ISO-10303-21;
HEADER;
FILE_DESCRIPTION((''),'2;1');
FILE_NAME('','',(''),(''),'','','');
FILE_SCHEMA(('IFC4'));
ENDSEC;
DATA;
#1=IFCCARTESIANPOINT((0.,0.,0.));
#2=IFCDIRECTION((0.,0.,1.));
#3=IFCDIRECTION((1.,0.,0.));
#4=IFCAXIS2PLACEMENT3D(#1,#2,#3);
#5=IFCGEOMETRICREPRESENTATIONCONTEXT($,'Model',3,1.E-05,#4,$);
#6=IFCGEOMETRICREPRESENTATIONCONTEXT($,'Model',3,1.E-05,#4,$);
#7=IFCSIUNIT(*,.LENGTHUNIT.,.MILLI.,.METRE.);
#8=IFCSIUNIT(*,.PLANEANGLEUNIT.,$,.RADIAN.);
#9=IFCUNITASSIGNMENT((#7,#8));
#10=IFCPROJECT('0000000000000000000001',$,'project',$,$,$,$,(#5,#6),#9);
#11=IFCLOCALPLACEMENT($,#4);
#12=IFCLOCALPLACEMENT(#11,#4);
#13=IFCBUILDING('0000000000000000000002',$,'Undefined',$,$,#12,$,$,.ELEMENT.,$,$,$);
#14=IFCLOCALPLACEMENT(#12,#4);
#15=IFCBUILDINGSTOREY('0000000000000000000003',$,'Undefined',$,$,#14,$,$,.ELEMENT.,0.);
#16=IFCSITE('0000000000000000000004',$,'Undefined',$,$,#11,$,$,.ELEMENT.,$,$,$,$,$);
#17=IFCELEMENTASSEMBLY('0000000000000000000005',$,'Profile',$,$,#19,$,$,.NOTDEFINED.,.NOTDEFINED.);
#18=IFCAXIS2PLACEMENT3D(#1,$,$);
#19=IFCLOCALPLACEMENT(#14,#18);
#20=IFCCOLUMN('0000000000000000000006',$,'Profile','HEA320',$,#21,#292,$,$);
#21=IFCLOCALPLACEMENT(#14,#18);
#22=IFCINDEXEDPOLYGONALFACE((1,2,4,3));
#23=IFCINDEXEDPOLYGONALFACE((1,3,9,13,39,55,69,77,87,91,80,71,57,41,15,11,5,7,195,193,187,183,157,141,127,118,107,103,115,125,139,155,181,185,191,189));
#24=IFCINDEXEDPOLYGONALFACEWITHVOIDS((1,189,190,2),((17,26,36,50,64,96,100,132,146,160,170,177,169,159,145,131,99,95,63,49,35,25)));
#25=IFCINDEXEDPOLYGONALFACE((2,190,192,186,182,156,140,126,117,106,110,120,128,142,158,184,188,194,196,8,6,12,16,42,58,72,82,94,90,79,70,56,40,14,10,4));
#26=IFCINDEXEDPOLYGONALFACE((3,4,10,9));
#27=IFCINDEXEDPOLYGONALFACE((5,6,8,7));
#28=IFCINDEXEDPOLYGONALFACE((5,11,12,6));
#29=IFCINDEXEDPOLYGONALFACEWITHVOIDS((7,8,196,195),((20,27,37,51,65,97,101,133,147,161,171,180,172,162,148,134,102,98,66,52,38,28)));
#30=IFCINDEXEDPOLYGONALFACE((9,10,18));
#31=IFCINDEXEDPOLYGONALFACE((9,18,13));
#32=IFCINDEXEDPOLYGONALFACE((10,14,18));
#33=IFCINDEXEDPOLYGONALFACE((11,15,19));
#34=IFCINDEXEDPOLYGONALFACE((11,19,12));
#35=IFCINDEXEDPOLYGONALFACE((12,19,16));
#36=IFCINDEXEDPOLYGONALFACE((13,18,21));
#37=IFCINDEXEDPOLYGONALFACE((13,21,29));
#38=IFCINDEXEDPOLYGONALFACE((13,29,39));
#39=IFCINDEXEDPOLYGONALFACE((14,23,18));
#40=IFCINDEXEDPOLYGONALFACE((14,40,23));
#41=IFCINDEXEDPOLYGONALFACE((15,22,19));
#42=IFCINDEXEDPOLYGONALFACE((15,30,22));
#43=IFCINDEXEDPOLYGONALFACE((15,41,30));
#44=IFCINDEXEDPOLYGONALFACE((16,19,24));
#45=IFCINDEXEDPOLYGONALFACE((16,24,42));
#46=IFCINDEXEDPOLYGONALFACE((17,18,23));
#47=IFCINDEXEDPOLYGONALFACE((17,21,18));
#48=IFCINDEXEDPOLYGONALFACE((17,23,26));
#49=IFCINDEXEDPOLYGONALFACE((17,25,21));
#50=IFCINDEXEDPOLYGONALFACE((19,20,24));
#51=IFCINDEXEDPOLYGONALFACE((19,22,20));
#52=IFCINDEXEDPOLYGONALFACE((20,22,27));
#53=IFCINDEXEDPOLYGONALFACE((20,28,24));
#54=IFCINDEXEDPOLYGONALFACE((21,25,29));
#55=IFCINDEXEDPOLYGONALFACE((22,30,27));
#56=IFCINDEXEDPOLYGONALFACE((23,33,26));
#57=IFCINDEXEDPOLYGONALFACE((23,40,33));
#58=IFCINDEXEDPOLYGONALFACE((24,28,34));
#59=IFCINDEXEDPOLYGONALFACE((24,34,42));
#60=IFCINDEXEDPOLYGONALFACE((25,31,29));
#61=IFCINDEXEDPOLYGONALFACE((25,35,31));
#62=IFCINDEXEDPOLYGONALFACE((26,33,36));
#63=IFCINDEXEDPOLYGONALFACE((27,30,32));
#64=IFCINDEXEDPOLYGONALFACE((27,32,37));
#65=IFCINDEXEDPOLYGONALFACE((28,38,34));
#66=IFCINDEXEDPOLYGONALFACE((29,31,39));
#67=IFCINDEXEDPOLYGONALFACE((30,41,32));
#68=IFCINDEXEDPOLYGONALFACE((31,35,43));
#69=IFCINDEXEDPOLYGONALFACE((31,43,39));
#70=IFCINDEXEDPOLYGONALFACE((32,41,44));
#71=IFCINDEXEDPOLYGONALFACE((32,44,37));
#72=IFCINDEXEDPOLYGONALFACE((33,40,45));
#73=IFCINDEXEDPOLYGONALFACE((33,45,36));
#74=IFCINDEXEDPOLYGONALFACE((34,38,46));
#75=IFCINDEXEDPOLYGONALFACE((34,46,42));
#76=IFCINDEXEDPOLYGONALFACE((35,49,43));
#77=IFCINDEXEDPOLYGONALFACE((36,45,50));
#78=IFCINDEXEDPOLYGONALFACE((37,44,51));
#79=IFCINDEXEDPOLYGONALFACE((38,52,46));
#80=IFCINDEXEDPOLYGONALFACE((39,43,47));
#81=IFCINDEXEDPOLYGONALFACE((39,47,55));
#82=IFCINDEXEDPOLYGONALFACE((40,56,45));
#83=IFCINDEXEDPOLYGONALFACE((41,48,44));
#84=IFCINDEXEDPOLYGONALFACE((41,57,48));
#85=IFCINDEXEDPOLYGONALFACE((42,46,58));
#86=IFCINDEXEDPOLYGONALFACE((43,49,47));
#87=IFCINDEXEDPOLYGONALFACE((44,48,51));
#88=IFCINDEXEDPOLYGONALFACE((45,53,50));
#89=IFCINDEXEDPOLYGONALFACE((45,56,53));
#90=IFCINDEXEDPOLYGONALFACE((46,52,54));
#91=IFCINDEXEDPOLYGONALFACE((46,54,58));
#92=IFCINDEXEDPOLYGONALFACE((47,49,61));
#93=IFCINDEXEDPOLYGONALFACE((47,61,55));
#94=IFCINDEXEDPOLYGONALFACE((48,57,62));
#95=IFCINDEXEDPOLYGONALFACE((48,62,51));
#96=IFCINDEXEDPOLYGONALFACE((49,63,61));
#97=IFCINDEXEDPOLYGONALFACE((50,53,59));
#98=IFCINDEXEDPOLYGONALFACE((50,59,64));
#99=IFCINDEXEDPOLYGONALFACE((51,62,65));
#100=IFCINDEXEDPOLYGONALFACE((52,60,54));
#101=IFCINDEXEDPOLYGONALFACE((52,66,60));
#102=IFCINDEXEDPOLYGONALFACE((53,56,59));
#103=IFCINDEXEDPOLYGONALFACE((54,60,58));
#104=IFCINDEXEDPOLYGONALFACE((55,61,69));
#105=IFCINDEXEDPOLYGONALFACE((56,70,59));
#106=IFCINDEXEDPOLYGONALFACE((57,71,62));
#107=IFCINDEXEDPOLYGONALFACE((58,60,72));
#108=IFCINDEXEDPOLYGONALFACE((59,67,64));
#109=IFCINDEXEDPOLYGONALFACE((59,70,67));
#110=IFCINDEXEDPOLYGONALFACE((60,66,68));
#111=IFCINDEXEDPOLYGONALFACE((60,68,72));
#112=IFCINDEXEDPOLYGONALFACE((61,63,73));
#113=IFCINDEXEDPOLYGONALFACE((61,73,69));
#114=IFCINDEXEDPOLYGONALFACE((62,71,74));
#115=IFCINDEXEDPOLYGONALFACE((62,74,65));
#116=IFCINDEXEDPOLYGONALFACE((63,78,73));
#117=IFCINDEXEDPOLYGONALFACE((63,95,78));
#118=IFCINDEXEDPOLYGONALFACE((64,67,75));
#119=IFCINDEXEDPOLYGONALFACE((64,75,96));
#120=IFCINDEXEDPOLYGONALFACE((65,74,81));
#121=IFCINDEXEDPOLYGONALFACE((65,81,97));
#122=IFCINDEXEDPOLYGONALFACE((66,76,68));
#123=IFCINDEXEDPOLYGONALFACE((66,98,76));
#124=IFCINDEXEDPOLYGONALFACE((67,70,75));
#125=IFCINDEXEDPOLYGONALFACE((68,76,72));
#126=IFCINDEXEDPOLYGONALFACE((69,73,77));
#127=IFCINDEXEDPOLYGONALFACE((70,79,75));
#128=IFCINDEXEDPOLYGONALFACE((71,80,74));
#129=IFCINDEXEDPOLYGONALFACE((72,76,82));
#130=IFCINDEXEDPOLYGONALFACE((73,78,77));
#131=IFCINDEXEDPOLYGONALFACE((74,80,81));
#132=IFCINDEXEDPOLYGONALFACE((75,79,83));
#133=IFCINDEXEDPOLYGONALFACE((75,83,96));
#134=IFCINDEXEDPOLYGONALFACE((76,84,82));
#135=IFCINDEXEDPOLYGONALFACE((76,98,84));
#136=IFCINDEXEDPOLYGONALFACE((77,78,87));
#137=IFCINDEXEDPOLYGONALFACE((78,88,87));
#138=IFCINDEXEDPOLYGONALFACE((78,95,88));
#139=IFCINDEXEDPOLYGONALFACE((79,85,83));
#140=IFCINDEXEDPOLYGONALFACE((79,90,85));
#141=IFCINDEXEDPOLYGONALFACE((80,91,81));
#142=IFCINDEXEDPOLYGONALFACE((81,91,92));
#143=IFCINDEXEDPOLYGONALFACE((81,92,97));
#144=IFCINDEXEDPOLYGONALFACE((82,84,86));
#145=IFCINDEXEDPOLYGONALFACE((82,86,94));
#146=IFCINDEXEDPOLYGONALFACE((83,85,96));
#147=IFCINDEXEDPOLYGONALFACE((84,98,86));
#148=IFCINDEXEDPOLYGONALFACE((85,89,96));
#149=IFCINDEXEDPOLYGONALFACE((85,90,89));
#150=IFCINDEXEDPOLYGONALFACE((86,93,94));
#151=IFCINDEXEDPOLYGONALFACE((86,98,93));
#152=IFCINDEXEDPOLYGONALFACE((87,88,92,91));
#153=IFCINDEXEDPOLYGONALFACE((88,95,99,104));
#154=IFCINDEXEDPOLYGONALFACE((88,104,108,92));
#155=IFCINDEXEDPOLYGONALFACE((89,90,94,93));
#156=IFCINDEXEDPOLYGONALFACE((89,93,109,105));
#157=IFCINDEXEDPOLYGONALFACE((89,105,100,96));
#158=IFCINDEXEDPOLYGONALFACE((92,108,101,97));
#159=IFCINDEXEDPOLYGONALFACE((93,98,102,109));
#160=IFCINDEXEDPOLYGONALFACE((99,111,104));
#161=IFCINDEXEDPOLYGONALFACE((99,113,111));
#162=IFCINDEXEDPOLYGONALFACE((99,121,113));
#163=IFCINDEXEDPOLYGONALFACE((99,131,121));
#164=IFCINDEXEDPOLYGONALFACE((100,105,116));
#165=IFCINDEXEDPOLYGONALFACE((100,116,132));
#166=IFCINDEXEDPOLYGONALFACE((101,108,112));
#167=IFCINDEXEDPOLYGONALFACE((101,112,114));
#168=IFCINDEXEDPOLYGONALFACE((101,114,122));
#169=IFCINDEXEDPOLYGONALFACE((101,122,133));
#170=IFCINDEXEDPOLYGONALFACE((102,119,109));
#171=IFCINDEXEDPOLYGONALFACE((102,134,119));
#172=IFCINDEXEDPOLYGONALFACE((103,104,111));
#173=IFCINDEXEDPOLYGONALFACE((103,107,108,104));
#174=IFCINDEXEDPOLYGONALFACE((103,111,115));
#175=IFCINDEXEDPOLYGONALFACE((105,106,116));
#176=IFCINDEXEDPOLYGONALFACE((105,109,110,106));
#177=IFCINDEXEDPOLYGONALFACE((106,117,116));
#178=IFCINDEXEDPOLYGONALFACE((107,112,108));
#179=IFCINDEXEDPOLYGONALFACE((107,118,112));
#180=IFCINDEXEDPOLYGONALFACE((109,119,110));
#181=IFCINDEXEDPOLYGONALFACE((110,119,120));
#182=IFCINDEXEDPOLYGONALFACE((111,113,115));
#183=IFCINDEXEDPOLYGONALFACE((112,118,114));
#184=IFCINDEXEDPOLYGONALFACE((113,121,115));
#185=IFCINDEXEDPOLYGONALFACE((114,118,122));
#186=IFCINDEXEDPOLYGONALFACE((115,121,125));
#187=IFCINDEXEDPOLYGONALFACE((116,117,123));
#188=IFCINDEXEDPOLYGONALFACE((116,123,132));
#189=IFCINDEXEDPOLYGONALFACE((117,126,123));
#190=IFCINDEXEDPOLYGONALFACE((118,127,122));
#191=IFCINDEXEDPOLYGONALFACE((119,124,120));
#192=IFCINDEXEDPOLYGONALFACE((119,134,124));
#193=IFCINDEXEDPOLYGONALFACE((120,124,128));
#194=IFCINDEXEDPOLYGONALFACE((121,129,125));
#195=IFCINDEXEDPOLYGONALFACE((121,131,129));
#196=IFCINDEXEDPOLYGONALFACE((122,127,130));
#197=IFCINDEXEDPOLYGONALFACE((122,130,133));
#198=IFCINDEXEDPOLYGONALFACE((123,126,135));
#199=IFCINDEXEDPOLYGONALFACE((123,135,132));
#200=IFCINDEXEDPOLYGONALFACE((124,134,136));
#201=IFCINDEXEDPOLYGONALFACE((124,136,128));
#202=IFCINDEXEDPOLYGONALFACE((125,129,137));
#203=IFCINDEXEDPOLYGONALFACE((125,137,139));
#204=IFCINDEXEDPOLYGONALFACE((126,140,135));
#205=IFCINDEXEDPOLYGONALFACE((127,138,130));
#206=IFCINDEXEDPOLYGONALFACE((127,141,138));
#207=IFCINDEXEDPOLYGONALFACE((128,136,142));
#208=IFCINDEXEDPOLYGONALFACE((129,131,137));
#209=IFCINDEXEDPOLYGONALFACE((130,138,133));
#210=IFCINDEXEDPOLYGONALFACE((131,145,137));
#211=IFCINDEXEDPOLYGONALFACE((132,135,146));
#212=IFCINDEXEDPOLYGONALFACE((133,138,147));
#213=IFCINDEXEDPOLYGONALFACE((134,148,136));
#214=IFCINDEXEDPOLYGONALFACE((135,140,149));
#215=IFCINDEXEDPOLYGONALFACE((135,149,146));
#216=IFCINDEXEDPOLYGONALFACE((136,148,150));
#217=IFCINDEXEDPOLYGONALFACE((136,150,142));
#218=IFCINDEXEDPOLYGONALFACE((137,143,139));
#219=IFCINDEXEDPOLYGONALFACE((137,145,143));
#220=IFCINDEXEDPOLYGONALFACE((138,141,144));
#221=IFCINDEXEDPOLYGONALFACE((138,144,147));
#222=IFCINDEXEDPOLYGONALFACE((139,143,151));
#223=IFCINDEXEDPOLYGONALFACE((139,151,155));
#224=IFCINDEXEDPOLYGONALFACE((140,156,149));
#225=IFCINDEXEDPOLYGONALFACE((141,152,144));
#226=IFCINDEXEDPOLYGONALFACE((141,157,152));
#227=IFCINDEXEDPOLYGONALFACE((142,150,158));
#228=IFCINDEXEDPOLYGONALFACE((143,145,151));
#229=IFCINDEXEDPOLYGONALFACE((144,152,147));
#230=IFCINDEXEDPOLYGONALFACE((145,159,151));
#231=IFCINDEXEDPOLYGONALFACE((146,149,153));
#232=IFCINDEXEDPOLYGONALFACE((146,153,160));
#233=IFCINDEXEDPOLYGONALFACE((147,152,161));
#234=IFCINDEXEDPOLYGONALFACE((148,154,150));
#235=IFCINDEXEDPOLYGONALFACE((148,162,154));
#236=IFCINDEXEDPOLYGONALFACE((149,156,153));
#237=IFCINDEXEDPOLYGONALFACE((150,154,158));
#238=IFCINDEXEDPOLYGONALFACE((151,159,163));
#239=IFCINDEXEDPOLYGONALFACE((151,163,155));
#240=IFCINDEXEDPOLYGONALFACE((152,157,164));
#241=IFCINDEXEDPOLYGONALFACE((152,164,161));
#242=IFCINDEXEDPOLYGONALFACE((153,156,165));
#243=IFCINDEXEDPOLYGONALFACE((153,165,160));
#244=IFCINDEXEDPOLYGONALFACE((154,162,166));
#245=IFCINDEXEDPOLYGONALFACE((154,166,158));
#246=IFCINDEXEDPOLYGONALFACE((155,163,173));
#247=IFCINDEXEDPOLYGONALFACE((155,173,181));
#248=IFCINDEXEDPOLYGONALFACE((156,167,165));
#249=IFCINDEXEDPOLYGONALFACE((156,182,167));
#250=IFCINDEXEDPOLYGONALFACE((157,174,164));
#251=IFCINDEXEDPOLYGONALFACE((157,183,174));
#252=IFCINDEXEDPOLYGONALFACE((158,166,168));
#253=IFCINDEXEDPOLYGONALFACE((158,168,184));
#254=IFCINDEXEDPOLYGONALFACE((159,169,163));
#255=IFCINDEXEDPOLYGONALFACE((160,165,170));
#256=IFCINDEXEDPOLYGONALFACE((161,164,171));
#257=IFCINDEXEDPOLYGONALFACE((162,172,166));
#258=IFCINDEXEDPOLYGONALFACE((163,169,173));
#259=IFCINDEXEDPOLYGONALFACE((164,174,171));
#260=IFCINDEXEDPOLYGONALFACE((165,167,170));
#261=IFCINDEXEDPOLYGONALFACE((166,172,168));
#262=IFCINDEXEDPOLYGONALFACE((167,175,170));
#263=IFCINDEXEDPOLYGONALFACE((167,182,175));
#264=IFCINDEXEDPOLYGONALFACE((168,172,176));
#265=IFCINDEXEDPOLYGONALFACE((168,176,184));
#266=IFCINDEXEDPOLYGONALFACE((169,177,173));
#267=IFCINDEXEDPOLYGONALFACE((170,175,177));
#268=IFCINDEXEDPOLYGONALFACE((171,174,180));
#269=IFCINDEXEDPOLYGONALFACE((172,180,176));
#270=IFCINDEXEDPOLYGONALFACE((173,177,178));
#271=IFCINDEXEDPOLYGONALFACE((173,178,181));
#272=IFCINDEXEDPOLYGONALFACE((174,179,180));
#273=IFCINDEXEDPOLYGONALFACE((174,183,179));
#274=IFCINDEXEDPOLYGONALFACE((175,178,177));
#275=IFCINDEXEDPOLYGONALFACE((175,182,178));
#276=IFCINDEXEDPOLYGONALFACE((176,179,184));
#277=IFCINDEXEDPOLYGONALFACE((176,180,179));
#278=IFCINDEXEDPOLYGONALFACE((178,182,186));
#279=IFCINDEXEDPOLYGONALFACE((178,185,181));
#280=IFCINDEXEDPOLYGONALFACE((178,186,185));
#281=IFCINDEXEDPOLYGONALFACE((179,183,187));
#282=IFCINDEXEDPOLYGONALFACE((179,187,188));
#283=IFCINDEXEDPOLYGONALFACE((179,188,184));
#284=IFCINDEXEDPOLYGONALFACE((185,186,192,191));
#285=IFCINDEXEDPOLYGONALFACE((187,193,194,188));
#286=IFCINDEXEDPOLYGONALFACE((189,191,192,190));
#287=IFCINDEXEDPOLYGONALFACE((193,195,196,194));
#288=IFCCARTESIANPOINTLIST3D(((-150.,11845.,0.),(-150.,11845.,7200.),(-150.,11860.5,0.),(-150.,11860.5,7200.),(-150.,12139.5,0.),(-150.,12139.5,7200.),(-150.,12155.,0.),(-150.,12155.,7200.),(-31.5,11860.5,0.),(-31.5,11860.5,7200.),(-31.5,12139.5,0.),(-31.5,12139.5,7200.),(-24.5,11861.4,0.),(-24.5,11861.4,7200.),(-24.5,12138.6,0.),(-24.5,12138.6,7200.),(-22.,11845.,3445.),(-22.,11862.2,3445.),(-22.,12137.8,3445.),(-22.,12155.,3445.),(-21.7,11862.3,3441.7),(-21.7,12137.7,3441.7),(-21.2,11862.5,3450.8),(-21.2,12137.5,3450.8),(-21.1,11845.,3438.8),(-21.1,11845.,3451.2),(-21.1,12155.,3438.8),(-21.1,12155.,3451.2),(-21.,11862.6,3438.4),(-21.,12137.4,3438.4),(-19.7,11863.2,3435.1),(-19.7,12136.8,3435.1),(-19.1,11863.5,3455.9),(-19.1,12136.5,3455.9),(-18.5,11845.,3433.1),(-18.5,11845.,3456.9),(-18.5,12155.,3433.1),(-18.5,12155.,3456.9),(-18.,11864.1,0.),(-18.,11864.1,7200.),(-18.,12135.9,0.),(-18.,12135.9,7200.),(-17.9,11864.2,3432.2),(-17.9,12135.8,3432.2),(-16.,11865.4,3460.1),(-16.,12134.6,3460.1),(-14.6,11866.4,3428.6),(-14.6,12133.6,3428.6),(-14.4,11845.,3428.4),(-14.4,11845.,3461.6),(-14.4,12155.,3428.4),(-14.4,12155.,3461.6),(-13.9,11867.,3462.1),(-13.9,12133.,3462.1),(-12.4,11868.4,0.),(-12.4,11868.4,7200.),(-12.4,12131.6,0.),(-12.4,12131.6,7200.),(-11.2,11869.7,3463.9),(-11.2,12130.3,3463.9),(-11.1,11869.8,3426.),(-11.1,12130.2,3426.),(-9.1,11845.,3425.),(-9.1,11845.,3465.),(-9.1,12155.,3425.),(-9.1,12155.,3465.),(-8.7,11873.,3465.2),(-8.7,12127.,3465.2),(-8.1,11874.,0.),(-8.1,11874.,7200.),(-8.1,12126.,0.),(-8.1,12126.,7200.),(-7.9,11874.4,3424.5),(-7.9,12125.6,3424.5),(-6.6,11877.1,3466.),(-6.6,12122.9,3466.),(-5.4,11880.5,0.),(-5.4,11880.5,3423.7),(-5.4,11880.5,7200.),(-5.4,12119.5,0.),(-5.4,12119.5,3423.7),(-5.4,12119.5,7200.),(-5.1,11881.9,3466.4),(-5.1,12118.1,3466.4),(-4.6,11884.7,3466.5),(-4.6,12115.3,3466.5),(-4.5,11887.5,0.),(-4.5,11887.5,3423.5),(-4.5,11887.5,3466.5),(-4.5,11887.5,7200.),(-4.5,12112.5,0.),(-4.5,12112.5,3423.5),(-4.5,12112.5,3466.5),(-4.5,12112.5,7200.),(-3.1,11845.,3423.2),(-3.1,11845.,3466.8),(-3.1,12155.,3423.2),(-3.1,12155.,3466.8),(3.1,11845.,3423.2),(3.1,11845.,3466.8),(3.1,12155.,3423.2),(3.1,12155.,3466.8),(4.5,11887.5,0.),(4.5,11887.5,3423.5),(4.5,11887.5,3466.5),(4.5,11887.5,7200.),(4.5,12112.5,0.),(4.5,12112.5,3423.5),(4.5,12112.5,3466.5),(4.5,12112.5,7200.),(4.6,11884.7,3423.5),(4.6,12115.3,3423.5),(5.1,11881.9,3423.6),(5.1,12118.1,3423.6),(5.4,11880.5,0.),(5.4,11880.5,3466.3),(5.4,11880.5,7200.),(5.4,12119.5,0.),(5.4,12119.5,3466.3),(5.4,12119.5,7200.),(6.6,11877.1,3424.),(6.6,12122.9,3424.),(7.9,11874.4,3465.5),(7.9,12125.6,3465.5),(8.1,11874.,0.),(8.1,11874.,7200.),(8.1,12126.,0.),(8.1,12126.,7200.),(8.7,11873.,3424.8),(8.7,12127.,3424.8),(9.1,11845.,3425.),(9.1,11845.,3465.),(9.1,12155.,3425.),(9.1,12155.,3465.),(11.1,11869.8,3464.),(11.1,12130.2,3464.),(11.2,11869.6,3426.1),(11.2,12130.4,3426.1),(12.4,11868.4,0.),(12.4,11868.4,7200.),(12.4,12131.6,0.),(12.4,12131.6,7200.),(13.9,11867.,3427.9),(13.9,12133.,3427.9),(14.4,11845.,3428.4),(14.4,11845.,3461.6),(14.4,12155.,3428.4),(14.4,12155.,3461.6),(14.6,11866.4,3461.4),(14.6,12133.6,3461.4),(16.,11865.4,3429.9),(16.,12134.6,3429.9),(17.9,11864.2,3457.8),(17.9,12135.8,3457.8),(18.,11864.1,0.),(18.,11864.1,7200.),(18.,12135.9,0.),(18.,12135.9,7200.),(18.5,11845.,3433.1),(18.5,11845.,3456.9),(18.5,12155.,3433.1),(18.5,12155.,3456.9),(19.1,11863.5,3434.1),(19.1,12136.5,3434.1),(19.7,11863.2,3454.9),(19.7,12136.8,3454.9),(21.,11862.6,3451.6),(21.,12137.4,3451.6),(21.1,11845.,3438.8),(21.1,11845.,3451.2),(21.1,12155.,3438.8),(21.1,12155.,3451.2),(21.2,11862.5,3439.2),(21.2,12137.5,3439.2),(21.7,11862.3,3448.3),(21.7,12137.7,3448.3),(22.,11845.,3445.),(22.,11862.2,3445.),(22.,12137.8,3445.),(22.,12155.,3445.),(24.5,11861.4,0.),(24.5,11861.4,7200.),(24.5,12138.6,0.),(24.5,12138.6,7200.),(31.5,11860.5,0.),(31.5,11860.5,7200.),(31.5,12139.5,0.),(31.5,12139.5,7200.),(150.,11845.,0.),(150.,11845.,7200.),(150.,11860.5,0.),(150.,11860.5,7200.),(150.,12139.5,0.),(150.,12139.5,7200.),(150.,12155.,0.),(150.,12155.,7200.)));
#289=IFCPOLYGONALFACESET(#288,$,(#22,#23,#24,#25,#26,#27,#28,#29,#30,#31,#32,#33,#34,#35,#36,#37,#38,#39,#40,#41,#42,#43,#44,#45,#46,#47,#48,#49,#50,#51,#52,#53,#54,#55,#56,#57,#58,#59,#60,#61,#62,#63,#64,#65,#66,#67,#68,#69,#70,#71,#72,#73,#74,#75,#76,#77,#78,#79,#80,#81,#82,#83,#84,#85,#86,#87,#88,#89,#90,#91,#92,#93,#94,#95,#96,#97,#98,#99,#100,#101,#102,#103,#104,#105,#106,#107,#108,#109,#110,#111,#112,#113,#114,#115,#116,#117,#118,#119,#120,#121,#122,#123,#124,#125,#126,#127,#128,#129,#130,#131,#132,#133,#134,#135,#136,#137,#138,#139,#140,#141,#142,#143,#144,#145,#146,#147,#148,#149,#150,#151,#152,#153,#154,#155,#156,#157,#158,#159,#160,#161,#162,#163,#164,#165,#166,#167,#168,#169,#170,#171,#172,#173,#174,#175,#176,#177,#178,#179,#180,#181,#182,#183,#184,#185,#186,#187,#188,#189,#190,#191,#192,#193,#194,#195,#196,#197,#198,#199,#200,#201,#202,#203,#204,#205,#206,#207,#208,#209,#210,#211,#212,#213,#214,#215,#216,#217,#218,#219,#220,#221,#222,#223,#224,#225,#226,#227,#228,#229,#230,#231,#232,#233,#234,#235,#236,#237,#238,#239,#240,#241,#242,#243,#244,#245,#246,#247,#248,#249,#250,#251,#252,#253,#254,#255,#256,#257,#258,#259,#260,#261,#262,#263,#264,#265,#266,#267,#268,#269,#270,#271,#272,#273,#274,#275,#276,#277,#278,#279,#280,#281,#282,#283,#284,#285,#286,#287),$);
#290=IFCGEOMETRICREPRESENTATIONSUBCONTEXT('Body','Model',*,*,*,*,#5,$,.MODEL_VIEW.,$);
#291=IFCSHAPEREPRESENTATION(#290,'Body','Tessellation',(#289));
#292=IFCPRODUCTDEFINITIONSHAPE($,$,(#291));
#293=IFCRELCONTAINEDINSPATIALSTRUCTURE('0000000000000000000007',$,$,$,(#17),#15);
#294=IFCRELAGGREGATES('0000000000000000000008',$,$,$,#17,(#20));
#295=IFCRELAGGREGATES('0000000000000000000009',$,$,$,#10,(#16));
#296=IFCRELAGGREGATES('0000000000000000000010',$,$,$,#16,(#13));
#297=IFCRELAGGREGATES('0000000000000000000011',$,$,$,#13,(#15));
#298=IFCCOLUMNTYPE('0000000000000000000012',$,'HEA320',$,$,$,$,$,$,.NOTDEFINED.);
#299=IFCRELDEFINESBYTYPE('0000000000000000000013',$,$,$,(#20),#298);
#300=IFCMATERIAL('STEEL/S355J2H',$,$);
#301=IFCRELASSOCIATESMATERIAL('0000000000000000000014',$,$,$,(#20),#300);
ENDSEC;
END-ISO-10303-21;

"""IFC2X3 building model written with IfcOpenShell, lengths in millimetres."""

from ifc_helpers import new_model, si_unit, frame, origin_with_axes, origin_2d_with_axis, place, context, subcontext, project, spatial, circle, i_section, extrude, material, type_object, element, aggregate, save


model = new_model("IFC2X3")

# Units and contexts
model_context_1 = context("Model", 3, precision=1e-05, world=origin_with_axes())
model_context_2 = context("Model", 3, precision=1e-05, world=origin_with_axes())
body_context = subcontext(model_context_1, "Body", "Model", "MODEL_VIEW")
ifc_project = project(units=[si_unit("LENGTHUNIT", "METRE", prefix="MILLI"), si_unit("PLANEANGLEUNIT", "RADIAN")], contexts=[model_context_1, model_context_2])

# Site, building, storey
site_placement = place(None, origin_with_axes())
site = spatial("IfcSite", under=ifc_project, at=site_placement, Name="Undefined", CompositionType="ELEMENT")
building_placement = place(site_placement, origin_with_axes())
building = spatial("IfcBuilding", under=site, at=building_placement, Name="Undefined", CompositionType="ELEMENT")
storey_placement = place(building_placement, origin_with_axes())
storey = spatial("IfcBuildingStorey", under=building, at=storey_placement, Name="Undefined", CompositionType="ELEMENT", Elevation=0.0)

# Element assembly, column, openings
assembly_1_placement = place(storey_placement, origin_with_axes())
assembly_1 = element("IfcElementAssembly", 1, at=assembly_1_placement, inside=storey, Name="Profile", AssemblyPlace="NOTDEFINED", PredefinedType="NOTDEFINED")
ifc_material_1 = material(Name="STEEL/S355J2H")
column_type = type_object("IfcColumnType", Name="HEA320", PredefinedType="NOTDEFINED")
column_placement = place(assembly_1_placement, frame((0.0, 12000.0, 0.0), z_axis=(0.0, 0.0, 1.0), x_axis=(0.0, 1.0, 0.0)))
column = element("IfcColumn", 2, at=column_placement, type_object=column_type, material=ifc_material_1, Name="Profile", Description="HEA320", context=body_context, shape_type="SweptSolid", body=[
    extrude(i_section(OverallWidth=300.0, OverallDepth=310.0, WebThickness=9.0, FlangeThickness=15.5, FilletRadius=27.0, at=origin_2d_with_axis()), frame((0.0, 0.0, 7200.0), z_axis=(0.0, 0.0, -1.0), x_axis=(0.0, 1.0, 0.0)), (0.0, 0.0, 1.0), 7200.0),
])
opening_1_placement = place(assembly_1_placement, frame((0.0, 12000.0, 0.0), z_axis=(0.0, 0.0, 1.0), x_axis=(0.0, 1.0, 0.0)))
element("IfcOpeningElement", 3, at=opening_1_placement, cuts=column, ObjectType="Recess", context=body_context, shape_type="SweptSolid", body=[
    extrude(circle(Radius=22.0, at=origin_2d_with_axis()), frame((156.0, 0.0, 3445.0), z_axis=(-1.0, 0.0, 0.0), x_axis=(0.0, -1.0, 0.0)), (0.0, 0.0, 1.0), 312.0),
])
opening_2_placement = place(assembly_1_placement, frame((0.0, 12000.0, 0.0), z_axis=(0.0, 0.0, 1.0), x_axis=(0.0, 1.0, 0.0)))
element("IfcOpeningElement", 4, at=opening_2_placement, cuts=column, ObjectType="Recess", context=body_context, shape_type="SweptSolid", body=[
    extrude(circle(Radius=22.0, at=origin_2d_with_axis()), frame((-156.0, 0.0, 3445.0), z_axis=(1.0, 0.0, 0.0), x_axis=(0.0, 1.0, 0.0)), (0.0, 0.0, 1.0), 312.0),
])

aggregate(assembly_1, [column])

save(model, "model.ifc")
